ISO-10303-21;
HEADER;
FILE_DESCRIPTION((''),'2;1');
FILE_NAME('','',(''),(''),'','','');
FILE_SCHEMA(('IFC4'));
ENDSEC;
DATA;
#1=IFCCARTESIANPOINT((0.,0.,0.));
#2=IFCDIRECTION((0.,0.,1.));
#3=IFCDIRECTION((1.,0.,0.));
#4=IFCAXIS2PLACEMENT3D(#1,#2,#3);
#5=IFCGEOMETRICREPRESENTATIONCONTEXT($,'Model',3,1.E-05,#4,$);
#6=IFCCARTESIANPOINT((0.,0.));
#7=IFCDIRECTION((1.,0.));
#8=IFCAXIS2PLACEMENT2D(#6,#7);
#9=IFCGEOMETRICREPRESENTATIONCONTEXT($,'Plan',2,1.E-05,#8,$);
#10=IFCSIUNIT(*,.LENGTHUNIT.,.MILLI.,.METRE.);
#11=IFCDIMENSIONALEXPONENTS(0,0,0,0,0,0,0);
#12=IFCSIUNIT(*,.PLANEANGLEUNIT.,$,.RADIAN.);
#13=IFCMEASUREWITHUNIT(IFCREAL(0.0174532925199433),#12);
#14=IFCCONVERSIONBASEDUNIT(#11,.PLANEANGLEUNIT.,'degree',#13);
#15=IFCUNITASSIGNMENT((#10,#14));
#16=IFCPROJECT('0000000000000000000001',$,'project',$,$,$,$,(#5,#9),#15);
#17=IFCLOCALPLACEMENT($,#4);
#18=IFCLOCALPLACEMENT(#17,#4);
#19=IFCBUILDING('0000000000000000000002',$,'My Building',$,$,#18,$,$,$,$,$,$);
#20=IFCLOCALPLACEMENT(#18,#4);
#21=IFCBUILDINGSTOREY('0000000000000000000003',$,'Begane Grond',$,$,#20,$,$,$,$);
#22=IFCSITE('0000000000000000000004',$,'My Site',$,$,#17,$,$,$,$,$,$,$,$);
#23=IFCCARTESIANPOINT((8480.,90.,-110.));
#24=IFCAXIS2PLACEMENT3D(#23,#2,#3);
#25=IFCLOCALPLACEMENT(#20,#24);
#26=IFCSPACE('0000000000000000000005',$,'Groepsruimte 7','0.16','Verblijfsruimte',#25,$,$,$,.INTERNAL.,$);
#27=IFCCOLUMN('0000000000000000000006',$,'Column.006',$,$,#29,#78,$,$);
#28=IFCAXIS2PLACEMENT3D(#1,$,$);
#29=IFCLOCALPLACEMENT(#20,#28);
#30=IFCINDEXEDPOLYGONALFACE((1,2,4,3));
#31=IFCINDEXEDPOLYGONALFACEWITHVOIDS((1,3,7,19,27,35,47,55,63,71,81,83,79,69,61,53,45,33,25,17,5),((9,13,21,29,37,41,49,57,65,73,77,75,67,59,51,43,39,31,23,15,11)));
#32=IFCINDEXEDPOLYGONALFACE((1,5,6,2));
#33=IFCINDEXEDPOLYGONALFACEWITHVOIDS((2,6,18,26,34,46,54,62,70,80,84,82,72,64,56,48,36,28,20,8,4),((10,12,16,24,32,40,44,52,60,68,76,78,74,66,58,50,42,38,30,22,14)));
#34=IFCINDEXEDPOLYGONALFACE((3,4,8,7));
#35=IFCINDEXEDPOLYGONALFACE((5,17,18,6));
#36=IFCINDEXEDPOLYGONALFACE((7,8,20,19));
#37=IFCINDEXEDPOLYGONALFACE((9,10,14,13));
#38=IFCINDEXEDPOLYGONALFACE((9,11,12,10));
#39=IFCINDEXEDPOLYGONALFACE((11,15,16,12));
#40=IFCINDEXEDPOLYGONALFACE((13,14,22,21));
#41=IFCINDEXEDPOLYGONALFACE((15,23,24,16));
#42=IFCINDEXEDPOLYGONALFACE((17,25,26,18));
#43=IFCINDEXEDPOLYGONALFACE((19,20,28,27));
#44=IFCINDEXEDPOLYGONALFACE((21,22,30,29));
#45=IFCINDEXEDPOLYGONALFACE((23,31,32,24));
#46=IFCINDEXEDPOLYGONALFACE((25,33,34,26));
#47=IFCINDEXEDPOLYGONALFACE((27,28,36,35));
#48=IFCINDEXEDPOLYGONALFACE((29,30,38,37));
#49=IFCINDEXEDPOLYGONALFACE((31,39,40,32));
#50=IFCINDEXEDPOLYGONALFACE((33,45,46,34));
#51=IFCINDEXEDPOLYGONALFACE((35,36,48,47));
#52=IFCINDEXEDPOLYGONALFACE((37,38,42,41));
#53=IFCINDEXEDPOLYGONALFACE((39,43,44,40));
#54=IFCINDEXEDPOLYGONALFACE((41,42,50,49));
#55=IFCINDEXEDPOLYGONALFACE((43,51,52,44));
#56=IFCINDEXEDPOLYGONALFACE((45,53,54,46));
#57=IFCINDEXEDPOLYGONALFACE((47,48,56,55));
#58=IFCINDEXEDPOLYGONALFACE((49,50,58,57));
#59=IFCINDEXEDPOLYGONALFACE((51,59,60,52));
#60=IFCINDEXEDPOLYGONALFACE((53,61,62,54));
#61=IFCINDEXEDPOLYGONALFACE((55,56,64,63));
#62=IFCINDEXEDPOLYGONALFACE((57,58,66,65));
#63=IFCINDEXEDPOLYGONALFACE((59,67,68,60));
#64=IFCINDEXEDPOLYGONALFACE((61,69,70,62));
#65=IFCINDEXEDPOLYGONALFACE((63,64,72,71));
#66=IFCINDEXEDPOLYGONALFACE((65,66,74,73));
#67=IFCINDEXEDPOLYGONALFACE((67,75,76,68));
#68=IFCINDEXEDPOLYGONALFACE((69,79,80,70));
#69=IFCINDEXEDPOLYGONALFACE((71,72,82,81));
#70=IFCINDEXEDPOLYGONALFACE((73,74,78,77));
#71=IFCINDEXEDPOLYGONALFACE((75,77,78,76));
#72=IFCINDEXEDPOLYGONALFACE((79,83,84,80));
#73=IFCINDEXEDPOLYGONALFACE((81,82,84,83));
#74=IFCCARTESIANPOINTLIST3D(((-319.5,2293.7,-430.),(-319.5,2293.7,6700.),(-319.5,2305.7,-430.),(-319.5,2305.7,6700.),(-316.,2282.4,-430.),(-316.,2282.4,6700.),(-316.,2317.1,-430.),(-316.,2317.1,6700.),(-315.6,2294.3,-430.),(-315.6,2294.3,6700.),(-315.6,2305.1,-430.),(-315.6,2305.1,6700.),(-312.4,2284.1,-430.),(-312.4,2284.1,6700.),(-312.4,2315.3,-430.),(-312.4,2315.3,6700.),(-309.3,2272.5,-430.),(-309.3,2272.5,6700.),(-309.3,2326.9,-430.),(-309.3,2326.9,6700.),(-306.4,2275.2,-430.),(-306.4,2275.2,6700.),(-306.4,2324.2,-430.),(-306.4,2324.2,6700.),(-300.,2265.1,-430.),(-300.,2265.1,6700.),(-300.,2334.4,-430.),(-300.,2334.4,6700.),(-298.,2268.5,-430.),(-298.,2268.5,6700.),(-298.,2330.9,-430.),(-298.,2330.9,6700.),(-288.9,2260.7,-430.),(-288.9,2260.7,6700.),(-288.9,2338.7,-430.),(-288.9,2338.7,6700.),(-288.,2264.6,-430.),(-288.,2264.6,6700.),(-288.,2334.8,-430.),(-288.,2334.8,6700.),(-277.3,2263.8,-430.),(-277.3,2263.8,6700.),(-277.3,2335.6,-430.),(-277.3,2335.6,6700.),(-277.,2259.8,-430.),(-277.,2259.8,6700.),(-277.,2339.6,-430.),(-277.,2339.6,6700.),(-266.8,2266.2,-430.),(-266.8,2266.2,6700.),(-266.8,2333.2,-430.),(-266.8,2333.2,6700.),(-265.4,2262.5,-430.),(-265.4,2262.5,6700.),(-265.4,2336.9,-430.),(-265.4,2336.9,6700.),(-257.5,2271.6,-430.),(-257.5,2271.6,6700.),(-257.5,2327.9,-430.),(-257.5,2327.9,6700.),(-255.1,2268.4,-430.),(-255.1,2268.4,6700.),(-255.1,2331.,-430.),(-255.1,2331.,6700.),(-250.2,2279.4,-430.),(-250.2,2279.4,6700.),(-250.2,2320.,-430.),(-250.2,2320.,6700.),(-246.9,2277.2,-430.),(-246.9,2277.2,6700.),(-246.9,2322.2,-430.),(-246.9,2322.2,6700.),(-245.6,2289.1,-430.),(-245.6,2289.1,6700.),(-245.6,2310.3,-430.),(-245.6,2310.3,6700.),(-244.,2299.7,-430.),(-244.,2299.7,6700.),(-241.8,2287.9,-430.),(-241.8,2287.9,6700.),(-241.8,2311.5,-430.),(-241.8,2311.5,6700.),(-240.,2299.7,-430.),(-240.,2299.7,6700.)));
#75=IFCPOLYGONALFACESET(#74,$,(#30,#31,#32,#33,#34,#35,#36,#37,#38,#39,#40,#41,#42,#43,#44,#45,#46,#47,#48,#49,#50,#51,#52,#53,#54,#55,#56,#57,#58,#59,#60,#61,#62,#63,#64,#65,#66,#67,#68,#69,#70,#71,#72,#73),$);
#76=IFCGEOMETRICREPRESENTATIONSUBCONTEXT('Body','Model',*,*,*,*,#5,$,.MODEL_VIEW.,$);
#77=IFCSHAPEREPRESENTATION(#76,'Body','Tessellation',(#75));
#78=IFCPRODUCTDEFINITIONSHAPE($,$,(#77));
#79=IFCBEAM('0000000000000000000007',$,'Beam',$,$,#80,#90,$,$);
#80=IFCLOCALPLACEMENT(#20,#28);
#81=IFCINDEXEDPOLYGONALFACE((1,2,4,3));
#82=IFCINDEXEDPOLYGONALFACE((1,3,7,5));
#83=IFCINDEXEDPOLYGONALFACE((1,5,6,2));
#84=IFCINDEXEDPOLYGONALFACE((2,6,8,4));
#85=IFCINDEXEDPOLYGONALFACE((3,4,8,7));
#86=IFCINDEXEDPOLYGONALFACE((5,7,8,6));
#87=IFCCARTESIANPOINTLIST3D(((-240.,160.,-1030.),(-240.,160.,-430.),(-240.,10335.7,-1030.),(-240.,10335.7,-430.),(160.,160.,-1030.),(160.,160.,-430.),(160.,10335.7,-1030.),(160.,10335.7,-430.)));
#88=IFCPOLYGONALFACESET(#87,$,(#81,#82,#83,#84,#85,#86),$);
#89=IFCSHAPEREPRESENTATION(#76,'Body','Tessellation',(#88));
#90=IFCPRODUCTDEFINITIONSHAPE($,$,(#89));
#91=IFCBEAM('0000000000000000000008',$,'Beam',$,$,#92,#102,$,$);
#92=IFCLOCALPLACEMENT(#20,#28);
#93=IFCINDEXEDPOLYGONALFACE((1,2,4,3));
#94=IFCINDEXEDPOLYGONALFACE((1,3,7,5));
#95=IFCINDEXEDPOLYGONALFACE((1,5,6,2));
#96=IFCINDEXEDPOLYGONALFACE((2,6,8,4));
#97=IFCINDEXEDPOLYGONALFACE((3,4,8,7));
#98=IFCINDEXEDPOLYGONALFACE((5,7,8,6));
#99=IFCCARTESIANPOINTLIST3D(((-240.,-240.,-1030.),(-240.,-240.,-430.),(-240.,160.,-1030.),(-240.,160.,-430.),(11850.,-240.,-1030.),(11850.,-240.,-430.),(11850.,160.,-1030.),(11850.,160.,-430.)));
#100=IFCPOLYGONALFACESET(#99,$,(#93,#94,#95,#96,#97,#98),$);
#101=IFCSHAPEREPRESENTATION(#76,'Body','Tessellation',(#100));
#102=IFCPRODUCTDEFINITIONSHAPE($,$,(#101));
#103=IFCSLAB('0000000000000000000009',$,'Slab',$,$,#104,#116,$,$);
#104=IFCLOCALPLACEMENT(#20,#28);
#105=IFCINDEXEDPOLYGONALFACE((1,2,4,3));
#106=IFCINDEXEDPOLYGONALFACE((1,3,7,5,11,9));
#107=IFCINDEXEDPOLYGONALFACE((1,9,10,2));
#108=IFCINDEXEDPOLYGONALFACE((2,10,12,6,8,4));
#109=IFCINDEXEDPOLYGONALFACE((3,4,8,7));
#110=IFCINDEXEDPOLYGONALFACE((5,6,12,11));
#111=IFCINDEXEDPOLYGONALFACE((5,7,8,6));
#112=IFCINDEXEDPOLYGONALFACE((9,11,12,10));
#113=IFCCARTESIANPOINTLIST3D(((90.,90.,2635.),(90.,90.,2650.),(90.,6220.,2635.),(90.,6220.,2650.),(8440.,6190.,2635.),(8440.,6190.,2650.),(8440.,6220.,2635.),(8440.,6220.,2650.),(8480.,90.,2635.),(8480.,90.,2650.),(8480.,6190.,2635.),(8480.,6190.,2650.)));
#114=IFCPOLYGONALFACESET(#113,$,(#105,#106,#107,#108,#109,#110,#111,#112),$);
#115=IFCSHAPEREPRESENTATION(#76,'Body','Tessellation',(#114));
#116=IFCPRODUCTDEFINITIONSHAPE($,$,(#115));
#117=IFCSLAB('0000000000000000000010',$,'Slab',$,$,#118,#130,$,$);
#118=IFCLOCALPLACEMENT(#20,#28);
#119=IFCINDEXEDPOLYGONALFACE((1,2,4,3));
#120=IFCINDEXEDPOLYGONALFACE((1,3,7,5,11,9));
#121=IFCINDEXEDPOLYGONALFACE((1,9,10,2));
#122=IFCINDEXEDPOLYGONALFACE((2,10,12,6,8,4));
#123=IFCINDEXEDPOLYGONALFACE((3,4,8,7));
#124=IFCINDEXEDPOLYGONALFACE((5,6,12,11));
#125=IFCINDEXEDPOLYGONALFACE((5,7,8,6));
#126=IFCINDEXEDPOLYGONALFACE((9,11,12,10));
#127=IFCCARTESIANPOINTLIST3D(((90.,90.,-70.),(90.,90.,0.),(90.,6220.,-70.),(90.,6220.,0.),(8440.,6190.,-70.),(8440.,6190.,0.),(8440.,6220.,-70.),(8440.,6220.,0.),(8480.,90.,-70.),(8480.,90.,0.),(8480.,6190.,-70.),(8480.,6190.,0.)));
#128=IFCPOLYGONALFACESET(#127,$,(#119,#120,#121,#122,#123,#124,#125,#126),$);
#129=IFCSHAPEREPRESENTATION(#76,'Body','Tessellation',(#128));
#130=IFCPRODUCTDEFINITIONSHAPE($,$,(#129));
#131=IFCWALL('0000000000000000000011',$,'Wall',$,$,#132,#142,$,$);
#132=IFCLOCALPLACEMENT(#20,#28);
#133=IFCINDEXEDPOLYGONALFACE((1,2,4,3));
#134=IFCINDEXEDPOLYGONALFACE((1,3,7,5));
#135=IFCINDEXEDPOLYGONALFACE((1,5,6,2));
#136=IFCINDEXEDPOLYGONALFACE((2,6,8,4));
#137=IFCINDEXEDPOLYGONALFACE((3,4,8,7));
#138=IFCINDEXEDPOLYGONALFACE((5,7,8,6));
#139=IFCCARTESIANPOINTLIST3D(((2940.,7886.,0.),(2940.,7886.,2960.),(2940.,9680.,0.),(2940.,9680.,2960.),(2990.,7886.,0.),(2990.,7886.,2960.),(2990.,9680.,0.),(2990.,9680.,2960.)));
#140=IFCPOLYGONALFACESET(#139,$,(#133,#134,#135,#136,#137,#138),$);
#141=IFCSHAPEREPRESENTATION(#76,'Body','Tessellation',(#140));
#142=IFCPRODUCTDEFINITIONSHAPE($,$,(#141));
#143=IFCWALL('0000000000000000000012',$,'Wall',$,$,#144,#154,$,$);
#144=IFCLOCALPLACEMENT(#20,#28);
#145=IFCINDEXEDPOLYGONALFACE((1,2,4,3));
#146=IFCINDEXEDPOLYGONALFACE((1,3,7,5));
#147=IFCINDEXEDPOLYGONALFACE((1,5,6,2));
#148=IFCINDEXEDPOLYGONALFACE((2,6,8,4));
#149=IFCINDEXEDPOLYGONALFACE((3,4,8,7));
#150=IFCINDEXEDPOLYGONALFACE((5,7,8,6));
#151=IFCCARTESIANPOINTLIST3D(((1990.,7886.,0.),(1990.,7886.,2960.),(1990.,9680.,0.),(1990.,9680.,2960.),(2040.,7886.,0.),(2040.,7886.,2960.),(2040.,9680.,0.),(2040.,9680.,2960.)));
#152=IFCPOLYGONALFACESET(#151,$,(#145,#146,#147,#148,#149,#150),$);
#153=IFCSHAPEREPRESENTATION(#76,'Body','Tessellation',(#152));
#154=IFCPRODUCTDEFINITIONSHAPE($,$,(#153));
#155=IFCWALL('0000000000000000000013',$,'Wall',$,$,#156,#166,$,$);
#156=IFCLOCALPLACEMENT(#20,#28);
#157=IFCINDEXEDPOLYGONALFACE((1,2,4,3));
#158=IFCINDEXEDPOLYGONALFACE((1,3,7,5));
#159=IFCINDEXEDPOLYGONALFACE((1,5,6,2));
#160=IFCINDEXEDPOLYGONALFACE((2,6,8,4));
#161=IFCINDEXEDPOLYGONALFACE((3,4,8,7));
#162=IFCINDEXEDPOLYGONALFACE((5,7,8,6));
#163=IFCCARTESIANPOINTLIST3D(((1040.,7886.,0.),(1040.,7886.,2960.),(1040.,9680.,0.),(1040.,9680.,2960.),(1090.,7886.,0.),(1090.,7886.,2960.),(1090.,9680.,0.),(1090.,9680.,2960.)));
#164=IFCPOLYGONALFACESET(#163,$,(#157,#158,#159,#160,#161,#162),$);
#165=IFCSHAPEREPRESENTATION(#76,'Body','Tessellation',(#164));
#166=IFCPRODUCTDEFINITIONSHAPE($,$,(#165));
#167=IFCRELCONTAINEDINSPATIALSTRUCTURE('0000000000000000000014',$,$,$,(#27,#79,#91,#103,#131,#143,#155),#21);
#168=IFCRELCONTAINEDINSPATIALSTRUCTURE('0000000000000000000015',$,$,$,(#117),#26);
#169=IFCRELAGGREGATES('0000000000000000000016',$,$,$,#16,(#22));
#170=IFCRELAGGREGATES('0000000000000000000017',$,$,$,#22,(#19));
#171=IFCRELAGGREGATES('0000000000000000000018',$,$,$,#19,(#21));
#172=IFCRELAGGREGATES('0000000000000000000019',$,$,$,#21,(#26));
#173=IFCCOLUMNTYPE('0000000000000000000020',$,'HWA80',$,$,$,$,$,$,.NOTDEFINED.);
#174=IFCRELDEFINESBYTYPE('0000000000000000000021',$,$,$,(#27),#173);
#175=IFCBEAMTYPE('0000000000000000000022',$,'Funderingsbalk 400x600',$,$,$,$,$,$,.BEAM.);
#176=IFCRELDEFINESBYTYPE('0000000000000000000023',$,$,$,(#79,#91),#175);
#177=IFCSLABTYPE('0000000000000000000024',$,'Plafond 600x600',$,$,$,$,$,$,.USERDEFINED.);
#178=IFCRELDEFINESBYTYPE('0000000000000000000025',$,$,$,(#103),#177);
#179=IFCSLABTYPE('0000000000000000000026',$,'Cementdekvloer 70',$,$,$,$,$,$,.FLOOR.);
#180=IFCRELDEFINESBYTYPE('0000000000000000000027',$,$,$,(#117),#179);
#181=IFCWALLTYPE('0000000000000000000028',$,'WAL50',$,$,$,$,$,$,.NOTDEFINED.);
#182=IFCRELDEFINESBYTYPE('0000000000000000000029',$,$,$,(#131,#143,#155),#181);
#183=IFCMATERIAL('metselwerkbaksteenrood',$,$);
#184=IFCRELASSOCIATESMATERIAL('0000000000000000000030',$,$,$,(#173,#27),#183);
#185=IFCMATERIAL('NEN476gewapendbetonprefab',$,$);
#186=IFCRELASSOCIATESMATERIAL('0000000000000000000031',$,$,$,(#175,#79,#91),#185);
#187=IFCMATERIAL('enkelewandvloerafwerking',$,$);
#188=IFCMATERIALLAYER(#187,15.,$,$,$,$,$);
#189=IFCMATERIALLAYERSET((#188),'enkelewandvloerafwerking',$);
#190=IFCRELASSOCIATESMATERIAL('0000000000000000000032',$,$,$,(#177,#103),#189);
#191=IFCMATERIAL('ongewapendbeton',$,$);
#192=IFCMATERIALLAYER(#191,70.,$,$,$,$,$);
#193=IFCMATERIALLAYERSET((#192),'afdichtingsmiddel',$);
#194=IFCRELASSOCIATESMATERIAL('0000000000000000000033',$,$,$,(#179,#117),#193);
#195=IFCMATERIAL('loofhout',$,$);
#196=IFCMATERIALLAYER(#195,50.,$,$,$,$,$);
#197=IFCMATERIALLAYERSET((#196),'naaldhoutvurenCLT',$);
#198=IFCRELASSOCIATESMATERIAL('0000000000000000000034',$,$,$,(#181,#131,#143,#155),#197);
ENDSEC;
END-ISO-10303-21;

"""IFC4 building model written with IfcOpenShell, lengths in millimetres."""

from ifc_helpers import new_model, entity, si_unit, converted_unit, frame, origin_with_axes, origin_2d_with_axis, place, context, subcontext, project, spatial, line, indexed_curve, rectangle, hollow_circle, outline, extrude, clip, halfspace, material, layer, layer_set, layer_usage, material_profile, profile_set, profile_usage, type_object, element, save


model = new_model("IFC4")

# Units and contexts
model_context = context("Model", 3, precision=1e-05, world=origin_with_axes())
plan_context = context("Plan", 2, precision=1e-05, world=origin_2d_with_axis())
body_context = subcontext(model_context, "Body", "Model", "MODEL_VIEW")
ifc_project = project(units=[si_unit("LENGTHUNIT", "METRE", prefix="MILLI"), converted_unit("PLANEANGLEUNIT", "degree", entity("IfcReal", 0.0174532925199433), si_unit("PLANEANGLEUNIT", "RADIAN"), dimensions=[0, 0, 0, 0, 0, 0, 0])], contexts=[model_context, plan_context])

# Site, building, storey
site_placement = place(None, origin_with_axes())
site = spatial("IfcSite", under=ifc_project, at=site_placement, Name="My Site")
building_placement = place(site_placement, origin_with_axes())
building = spatial("IfcBuilding", under=site, at=building_placement, Name="My Building")
storey_placement = place(building_placement, origin_with_axes())
storey = spatial("IfcBuildingStorey", under=building, at=storey_placement, Name="Begane Grond")

# Column
ifc_material_1 = material(Name="metselwerkbaksteenrood")
ifc_material_profile_1 = material_profile(ifc_material_1, hollow_circle(Radius=40.0, WallThickness=4.0))
ifc_profile_set_1 = profile_set([ifc_material_profile_1])
ifc_profile_usage_1 = profile_usage(ifc_profile_set_1, cardinal=5)
column_type = type_object("IfcColumnType", Name="HWA80", PredefinedType="NOTDEFINED", material=ifc_profile_set_1)
column_placement = place(storey_placement, frame((-280.0, 2299.7, -430.0), z_axis=(0.0, 0.0, 1.0), x_axis=(1.0, 0.0, 0.0)))
element("IfcColumn", 1, at=column_placement, inside=storey, type_object=column_type, material=ifc_profile_usage_1, Name="Column.006", context=body_context, shape_type="SweptSolid", body=[
    extrude(hollow_circle(Radius=40.0, WallThickness=4.0), origin_with_axes(), (0.0, 0.0, 1.0), 7130.0),
])

# Beams
ifc_material_2 = material(Name="NEN476gewapendbetonprefab")
ifc_material_profile_2 = material_profile(ifc_material_2, rectangle(XDim=400.0, YDim=600.0))
ifc_profile_set_2 = profile_set([ifc_material_profile_2], Name="gewapendbetonprefab")
ifc_profile_usage_2 = profile_usage(ifc_profile_set_2, cardinal=5)
beam_type = type_object("IfcBeamType", Name="Funderingsbalk 400x600", PredefinedType="BEAM", material=ifc_profile_set_2)
beam_1_placement = place(storey_placement, frame((-40.0, 160.0, -730.0), z_axis=(0.0, 1.0, 0.0), x_axis=(-1.0, 0.0, 0.0)))
element("IfcBeam", 2, at=beam_1_placement, inside=storey, type_object=beam_type, material=ifc_profile_usage_2, Name="Beam", context=body_context, shape_type="SweptSolid", body=[
    extrude(rectangle(XDim=400.0, YDim=600.0), origin_with_axes(), (0.0, 0.0, 1.0), 10175.7),
])
ifc_profile_usage_3 = profile_usage(ifc_profile_set_2, cardinal=5)
beam_2_placement = place(storey_placement, frame((-240.0, -40.0, -730.0), z_axis=(1.0, 0.0, 0.0), x_axis=(0.0, 1.0, 0.0)))
element("IfcBeam", 3, at=beam_2_placement, inside=storey, type_object=beam_type, material=ifc_profile_usage_3, Name="Beam", context=body_context, shape_type="SweptSolid", body=[
    extrude(rectangle(XDim=400.0, YDim=600.0), origin_with_axes(), (0.0, 0.0, 1.0), 12090.0),
])

# Slab
ifc_material_3 = material(Name="enkelewandvloerafwerking")
ifc_layer_1 = layer(ifc_material_3, 15.0)
ifc_layer_set_1 = layer_set([ifc_layer_1], Name="enkelewandvloerafwerking")
ifc_layer_usage_1 = layer_usage(ifc_layer_set_1, "AXIS3", "POSITIVE", 0.0)
slab_type_1 = type_object("IfcSlabType", Name="Plafond 600x600", PredefinedType="USERDEFINED", material=ifc_layer_set_1)
slab_1_placement = place(storey_placement, frame((90.0, 90.0, 2635.0), z_axis=(0.0, 0.0, 1.0), x_axis=(1.0, 0.0, 0.0)))
element("IfcSlab", 4, at=slab_1_placement, inside=storey, type_object=slab_type_1, material=ifc_layer_usage_1, Name="Slab", context=body_context, shape_type="SweptSolid", body=[
    extrude(outline(indexed_curve([(0.0, 0.0), (8390.0, 0.0), (8350.0, 6130.0), (0.0, 6130.0), (8350.0, 6100.0), (8390.0, 6100.0)], segments=[line(3, 5), line(5, 6), line(6, 2), line(2, 1), line(1, 4), line(4, 3)], self_intersect=False)), None, (0.0, 0.0, 1.0), 15.0),
])

# Shared definitions
ifc_material_4 = material(Name="ongewapendbeton")
ifc_layer_2 = layer(ifc_material_4, 70.0)
ifc_layer_set_2 = layer_set([ifc_layer_2], Name="afdichtingsmiddel")
slab_type_2 = type_object("IfcSlabType", Name="Cementdekvloer 70", PredefinedType="FLOOR", material=ifc_layer_set_2)

# Shared definitions
space_1_placement = place(storey_placement, frame((8480.0, 90.0, -110.0), z_axis=(0.0, 0.0, 1.0), x_axis=(1.0, 0.0, 0.0)))
space_1 = spatial("IfcSpace", under=storey, at=space_1_placement, Name="Groepsruimte 7", Description="0.16", ObjectType="Verblijfsruimte", PredefinedType="INTERNAL")

# Slab
ifc_layer_usage_2 = layer_usage(ifc_layer_set_2, "AXIS3", "POSITIVE", 0.0)
slab_2_placement = place(space_1_placement, frame((-8390.0, 0.0, 40.0), z_axis=(0.0, 0.0, 1.0), x_axis=(1.0, 0.0, 0.0)))
element("IfcSlab", 5, at=slab_2_placement, inside=space_1, type_object=slab_type_2, material=ifc_layer_usage_2, Name="Slab", context=body_context, shape_type="SweptSolid", body=[
    extrude(outline(indexed_curve([(0.0, 0.0), (8390.0, 0.0), (8350.0, 6130.0), (0.0, 6130.0), (8350.0, 6100.0), (8390.0, 6100.0)], segments=[line(2, 1), line(1, 4), line(4, 3), line(3, 5), line(5, 6), line(6, 2)], self_intersect=False)), None, (0.0, 0.0, 1.0), 70.0),
])

# Walls
ifc_material_5 = material(Name="loofhout")
ifc_layer_3 = layer(ifc_material_5, 50.0)
ifc_layer_set_3 = layer_set([ifc_layer_3], Name="naaldhoutvurenCLT")
ifc_layer_usage_3 = layer_usage(ifc_layer_set_3, "AXIS2", "POSITIVE", 0.0)
wall_type_1 = type_object("IfcWallType", Name="WAL50", PredefinedType="NOTDEFINED", material=ifc_layer_set_3)
wall_1_placement = place(storey_placement, frame((2940.0, 9680.0, 0.0), z_axis=(0.0, 0.0, 1.0), x_axis=(0.0, -1.0, 0.0)))
element("IfcWall", 6, at=wall_1_placement, inside=storey, type_object=wall_type_1, material=ifc_layer_usage_3, Name="Wall", context=body_context, shape_type="Clipping", body=[
    clip(extrude(outline(indexed_curve([(0.0, 0.0), (0.0, 50.0), (1793.9, 50.0), (1793.9, 0.0), (0.0, 0.0)], self_intersect=False)), origin_with_axes(), (0.0, 0.0, 1.0), 2960.0), halfspace(frame((0.0, 0.0, 2960.0), z_axis=(0.0, 0.0, 1.0), x_axis=(-1.0, 0.0, 0.0)), False)),
])
ifc_layer_usage_4 = layer_usage(ifc_layer_set_3, "AXIS2", "POSITIVE", 0.0)
wall_2_placement = place(storey_placement, frame((1990.0, 9680.0, 0.0), z_axis=(0.0, 0.0, 1.0), x_axis=(0.0, -1.0, 0.0)))
element("IfcWall", 7, at=wall_2_placement, inside=storey, type_object=wall_type_1, material=ifc_layer_usage_4, Name="Wall", context=body_context, shape_type="Clipping", body=[
    clip(extrude(outline(indexed_curve([(0.0, 0.0), (0.0, 50.0), (1793.9, 50.0), (1793.9, 0.0), (0.0, 0.0)], self_intersect=False)), origin_with_axes(), (0.0, 0.0, 1.0), 2960.0), halfspace(frame((0.0, 0.0, 2960.0), z_axis=(0.0, 0.0, 1.0), x_axis=(-1.0, 0.0, 0.0)), False)),
])

# Wall
ifc_layer_usage_5 = layer_usage(ifc_layer_set_3, "AXIS2", "POSITIVE", 0.0)
wall_3_placement = place(storey_placement, frame((1040.0, 9680.0, 0.0), z_axis=(0.0, 0.0, 1.0), x_axis=(0.0, -1.0, 0.0)))
element("IfcWall", 8, at=wall_3_placement, inside=storey, type_object=wall_type_1, material=ifc_layer_usage_5, Name="Wall", context=body_context, shape_type="Clipping", body=[
    clip(extrude(outline(indexed_curve([(0.0, 0.0), (0.0, 50.0), (1793.9, 50.0), (1793.9, 0.0), (0.0, 0.0)], self_intersect=False)), origin_with_axes(), (0.0, 0.0, 1.0), 2960.0), halfspace(frame((0.0, 0.0, 2960.0), z_axis=(0.0, 0.0, 1.0), x_axis=(-1.0, 0.0, 0.0)), False)),
])

save(model, "model.ifc")
